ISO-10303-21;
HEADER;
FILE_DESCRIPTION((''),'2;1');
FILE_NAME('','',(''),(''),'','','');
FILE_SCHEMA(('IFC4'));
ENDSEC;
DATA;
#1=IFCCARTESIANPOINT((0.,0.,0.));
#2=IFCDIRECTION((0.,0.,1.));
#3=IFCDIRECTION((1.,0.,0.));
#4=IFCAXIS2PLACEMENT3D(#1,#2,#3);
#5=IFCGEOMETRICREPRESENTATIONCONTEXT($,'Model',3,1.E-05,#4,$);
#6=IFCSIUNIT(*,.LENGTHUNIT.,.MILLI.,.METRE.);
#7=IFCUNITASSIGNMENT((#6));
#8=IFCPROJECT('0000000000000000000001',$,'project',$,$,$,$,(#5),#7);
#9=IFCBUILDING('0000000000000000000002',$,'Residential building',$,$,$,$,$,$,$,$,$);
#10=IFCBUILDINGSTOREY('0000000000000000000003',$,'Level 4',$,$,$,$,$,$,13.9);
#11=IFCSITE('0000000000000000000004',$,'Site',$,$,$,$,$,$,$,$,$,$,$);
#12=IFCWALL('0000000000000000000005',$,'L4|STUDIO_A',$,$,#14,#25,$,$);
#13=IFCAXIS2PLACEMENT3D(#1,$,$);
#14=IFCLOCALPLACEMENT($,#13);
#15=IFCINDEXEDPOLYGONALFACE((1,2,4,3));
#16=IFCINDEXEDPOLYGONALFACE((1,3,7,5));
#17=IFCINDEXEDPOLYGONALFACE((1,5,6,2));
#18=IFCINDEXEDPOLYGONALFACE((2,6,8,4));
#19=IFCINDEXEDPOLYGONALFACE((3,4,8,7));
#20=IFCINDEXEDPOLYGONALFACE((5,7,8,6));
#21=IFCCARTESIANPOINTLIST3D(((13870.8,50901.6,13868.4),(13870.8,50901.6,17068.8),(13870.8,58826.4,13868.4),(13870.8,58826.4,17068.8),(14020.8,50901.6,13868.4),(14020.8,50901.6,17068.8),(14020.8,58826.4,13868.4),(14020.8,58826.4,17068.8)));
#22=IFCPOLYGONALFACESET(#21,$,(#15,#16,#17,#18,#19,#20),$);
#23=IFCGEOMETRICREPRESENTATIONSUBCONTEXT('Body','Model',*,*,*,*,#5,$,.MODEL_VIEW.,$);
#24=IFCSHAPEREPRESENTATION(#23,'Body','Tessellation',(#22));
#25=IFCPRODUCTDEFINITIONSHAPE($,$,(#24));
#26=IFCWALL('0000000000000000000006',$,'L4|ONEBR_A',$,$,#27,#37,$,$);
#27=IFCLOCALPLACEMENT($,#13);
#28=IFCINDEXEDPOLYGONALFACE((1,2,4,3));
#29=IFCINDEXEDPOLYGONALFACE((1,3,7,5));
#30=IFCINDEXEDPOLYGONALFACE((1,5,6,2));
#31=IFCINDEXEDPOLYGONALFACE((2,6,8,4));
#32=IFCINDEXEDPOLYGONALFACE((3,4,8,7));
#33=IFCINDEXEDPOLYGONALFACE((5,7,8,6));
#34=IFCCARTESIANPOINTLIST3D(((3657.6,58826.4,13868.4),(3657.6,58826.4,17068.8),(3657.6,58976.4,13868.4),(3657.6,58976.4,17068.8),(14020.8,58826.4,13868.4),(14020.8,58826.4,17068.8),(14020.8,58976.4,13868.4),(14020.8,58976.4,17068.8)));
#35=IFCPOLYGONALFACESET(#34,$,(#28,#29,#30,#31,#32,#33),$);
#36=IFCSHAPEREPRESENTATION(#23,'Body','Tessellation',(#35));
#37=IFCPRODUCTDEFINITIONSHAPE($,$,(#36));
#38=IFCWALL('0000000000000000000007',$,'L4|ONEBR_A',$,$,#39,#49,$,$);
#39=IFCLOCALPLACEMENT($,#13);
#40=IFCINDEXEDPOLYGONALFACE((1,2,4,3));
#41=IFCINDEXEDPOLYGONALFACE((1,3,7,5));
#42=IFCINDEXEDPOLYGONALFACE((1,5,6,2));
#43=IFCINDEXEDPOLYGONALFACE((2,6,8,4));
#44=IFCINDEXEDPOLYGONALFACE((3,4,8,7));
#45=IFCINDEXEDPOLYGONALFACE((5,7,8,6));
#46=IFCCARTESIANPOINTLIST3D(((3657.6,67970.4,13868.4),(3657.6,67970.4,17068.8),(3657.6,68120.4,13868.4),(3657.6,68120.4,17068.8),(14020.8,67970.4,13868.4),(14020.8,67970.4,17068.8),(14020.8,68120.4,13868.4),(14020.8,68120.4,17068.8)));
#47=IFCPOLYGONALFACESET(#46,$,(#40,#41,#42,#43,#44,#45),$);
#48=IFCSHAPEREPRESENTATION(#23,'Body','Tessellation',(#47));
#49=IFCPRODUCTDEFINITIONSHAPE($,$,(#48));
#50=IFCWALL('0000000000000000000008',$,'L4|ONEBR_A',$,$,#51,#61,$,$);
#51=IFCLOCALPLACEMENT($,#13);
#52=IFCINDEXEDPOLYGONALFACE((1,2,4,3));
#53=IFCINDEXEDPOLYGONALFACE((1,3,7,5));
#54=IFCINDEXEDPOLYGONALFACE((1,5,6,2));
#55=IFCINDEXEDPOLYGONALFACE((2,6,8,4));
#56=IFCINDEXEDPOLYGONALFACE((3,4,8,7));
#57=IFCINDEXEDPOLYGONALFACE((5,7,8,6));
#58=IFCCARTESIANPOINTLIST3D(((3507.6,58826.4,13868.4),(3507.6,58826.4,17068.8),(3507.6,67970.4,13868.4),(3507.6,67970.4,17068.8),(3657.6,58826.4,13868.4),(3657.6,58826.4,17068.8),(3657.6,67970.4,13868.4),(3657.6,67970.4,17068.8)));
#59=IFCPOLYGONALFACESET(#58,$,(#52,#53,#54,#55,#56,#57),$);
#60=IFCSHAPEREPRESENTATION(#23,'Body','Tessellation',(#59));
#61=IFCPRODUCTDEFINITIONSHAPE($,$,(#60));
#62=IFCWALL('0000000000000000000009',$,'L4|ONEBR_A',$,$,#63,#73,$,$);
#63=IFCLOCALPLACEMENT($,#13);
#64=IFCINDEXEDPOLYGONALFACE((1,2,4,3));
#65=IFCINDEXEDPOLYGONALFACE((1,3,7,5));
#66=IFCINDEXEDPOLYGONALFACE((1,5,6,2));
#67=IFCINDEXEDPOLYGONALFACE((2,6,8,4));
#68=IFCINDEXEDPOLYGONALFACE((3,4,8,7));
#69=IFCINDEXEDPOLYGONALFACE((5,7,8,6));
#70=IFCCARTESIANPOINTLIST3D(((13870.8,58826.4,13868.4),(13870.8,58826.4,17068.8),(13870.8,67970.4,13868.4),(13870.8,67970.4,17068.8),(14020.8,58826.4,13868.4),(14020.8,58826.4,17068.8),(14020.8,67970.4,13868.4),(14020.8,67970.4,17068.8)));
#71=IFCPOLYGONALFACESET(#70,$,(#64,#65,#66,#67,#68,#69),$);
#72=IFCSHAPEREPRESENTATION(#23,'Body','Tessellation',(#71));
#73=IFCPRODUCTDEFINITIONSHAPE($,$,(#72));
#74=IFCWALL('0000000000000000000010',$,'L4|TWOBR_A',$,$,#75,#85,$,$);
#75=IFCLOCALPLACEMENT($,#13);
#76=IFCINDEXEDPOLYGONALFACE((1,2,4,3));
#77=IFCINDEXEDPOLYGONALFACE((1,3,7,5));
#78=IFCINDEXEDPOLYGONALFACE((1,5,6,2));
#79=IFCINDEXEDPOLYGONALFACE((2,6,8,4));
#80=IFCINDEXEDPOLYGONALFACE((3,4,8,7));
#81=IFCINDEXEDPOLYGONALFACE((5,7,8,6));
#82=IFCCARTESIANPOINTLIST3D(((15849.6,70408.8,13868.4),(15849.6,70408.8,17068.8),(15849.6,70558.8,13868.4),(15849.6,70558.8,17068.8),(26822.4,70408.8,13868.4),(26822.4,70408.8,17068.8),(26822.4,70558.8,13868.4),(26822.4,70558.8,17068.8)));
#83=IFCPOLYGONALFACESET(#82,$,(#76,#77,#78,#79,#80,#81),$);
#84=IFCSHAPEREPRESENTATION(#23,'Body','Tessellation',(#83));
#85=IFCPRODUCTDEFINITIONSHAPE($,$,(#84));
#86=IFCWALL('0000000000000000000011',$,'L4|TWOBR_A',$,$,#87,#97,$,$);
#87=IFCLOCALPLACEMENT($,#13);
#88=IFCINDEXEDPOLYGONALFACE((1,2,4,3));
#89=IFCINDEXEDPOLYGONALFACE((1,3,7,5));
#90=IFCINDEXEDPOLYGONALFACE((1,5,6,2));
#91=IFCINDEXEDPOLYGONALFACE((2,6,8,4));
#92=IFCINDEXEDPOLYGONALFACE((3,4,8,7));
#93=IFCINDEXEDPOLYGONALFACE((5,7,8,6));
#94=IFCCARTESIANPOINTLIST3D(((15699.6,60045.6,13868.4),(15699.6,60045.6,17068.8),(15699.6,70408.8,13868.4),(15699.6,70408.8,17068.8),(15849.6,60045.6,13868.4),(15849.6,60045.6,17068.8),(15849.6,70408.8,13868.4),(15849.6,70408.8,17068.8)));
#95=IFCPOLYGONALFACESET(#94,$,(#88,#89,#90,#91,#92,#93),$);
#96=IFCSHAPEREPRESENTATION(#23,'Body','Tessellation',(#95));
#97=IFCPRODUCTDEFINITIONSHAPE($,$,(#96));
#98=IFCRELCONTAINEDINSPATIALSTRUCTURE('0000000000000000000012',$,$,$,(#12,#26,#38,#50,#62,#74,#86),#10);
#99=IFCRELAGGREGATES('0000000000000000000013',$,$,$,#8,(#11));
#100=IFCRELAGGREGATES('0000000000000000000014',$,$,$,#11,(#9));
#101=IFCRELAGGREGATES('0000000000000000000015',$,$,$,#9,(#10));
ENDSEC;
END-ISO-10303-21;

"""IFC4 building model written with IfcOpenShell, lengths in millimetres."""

from ifc_helpers import new_model, si_unit, frame, origin_with_axes, place, context, subcontext, project, spatial, indexed_curve, outline, extrude, element, save


model = new_model("IFC4")

# Units and contexts
model_context = context("Model", 3, precision=1e-05, world=origin_with_axes())
body_context = subcontext(model_context, "Body", "Model", "MODEL_VIEW")
ifc_project = project(units=[si_unit("LENGTHUNIT", "METRE", prefix="MILLI")], contexts=[model_context])

# Site, building, storey
site = spatial("IfcSite", under=ifc_project, Name="Site")
building = spatial("IfcBuilding", under=site, Name="Residential building")
storey = spatial("IfcBuildingStorey", under=building, Name="Level 4", Elevation=13.9)

# Walls
for number, where, z_axis, x_axis, name in (
    (1, (14020.8, 50901.6, 13868.4), (0.0, 0.0, 1.0), (0.0, 1.0, 0.0), "L4|STUDIO_A"),
):
    element("IfcWall", number, at=place(None, frame(where, z_axis=z_axis, x_axis=x_axis)), inside=storey, Name=name, context=body_context, shape_type="SweptSolid", body=[
        extrude(outline(indexed_curve([(0.0, 0.0), (0.0, 150.0), (7924.8, 150.0), (7924.8, 0.0), (0.0, 0.0)], self_intersect=False)), origin_with_axes(), (0.0, 0.0, 1.0), 3200.4),
    ])
for number, where, z_axis, x_axis, name in (
    (2, (3657.6, 58826.4, 13868.4), (0.0, 0.0, 1.0), (1.0, 0.0, 0.0), "L4|ONEBR_A"),
    (3, (3657.6, 67970.4, 13868.4), (0.0, 0.0, 1.0), (1.0, 0.0, 0.0), "L4|ONEBR_A"),
):
    element("IfcWall", number, at=place(None, frame(where, z_axis=z_axis, x_axis=x_axis)), inside=storey, Name=name, context=body_context, shape_type="SweptSolid", body=[
        extrude(outline(indexed_curve([(0.0, 0.0), (0.0, 150.0), (10363.2, 150.0), (10363.2, 0.0), (0.0, 0.0)], self_intersect=False)), origin_with_axes(), (0.0, 0.0, 1.0), 3200.4),
    ])
for number, where, z_axis, x_axis, name in (
    (4, (3657.6, 58826.4, 13868.4), (0.0, 0.0, 1.0), (0.0, 1.0, 0.0), "L4|ONEBR_A"),
    (5, (14020.8, 58826.4, 13868.4), (0.0, 0.0, 1.0), (0.0, 1.0, 0.0), "L4|ONEBR_A"),
):
    element("IfcWall", number, at=place(None, frame(where, z_axis=z_axis, x_axis=x_axis)), inside=storey, Name=name, context=body_context, shape_type="SweptSolid", body=[
        extrude(outline(indexed_curve([(0.0, 0.0), (0.0, 150.0), (9144.0, 150.0), (9144.0, 0.0), (0.0, 0.0)], self_intersect=False)), origin_with_axes(), (0.0, 0.0, 1.0), 3200.4),
    ])
for number, where, z_axis, x_axis, name in (
    (6, (15849.6, 70408.8, 13868.4), (0.0, 0.0, 1.0), (1.0, 0.0, 0.0), "L4|TWOBR_A"),
):
    element("IfcWall", number, at=place(None, frame(where, z_axis=z_axis, x_axis=x_axis)), inside=storey, Name=name, context=body_context, shape_type="SweptSolid", body=[
        extrude(outline(indexed_curve([(0.0, 0.0), (0.0, 150.0), (10972.8, 150.0), (10972.8, 0.0), (0.0, 0.0)], self_intersect=False)), origin_with_axes(), (0.0, 0.0, 1.0), 3200.4),
    ])
wall_1_placement = place(None, frame((15849.6, 60045.6, 13868.4), z_axis=(0.0, 0.0, 1.0), x_axis=(0.0, 1.0, 0.0)))
element("IfcWall", 7, at=wall_1_placement, inside=storey, Name="L4|TWOBR_A", context=body_context, shape_type="SweptSolid", body=[
    extrude(outline(indexed_curve([(0.0, 0.0), (0.0, 150.0), (10363.2, 150.0), (10363.2, 0.0), (0.0, 0.0)], self_intersect=False)), origin_with_axes(), (0.0, 0.0, 1.0), 3200.4),
])

save(model, "model.ifc")
